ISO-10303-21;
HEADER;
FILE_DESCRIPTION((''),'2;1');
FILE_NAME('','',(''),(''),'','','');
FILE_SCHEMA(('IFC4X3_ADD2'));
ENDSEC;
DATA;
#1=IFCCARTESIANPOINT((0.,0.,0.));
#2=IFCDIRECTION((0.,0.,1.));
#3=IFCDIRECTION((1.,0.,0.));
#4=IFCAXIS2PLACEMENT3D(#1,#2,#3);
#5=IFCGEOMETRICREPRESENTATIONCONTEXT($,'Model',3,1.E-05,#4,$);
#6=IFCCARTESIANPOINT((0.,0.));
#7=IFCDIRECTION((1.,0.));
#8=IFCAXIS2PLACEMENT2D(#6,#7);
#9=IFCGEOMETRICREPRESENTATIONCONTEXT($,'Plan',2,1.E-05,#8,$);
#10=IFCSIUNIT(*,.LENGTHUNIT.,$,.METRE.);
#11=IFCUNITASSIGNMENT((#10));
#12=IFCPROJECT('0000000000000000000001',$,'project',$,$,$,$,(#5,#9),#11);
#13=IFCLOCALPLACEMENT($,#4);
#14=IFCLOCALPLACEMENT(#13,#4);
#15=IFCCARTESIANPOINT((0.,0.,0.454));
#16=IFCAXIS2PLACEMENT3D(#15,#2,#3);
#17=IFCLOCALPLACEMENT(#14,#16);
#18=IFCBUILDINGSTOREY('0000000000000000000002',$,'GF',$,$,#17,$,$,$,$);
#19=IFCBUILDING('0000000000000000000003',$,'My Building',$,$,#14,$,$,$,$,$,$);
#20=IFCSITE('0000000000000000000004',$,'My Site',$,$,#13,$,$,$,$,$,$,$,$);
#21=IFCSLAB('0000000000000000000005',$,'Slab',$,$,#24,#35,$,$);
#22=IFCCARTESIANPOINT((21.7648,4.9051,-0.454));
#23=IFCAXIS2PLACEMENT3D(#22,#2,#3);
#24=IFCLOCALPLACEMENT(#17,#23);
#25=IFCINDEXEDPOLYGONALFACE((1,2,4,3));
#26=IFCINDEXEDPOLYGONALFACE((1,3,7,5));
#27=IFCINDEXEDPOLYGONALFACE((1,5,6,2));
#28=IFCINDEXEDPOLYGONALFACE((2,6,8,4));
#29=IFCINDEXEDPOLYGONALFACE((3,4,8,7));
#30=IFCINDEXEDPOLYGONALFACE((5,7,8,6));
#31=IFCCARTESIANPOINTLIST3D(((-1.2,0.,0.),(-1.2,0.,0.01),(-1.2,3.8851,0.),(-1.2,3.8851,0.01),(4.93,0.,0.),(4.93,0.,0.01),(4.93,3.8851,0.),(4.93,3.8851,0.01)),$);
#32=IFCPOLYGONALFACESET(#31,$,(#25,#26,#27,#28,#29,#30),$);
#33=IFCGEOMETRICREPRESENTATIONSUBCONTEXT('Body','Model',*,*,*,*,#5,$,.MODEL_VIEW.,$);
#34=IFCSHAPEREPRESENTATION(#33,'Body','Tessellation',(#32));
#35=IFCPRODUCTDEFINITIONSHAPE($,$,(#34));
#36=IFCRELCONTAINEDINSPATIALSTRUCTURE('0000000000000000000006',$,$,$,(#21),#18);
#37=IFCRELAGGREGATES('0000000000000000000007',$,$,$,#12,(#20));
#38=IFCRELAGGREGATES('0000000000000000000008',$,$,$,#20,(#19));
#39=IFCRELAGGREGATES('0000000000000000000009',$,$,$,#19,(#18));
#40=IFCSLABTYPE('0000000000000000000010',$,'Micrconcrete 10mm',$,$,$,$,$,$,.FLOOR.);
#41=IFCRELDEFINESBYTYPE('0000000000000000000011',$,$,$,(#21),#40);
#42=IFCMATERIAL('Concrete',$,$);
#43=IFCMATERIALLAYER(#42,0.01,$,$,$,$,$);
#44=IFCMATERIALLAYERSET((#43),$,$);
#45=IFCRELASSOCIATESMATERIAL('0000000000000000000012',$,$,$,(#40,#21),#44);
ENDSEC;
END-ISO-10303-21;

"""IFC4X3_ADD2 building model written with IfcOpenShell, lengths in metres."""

from ifc_helpers import new_model, si_unit, frame, origin_with_axes, origin_2d_with_axis, place, context, subcontext, project, spatial, line, indexed_curve, outline, extrude, material, layer, layer_set, layer_usage, type_object, element, save


model = new_model("IFC4X3_ADD2")

# Units and contexts
model_context = context("Model", 3, precision=1e-05, world=origin_with_axes())
plan_context = context("Plan", 2, precision=1e-05, world=origin_2d_with_axis())
body_context = subcontext(model_context, "Body", "Model", "MODEL_VIEW")
ifc_project = project(units=[si_unit("LENGTHUNIT", "METRE")], contexts=[model_context, plan_context])

# Site, building, storey
site_placement = place(None, origin_with_axes())
site = spatial("IfcSite", under=ifc_project, at=site_placement, Name="My Site")
building_placement = place(site_placement, origin_with_axes())
building = spatial("IfcBuilding", under=site, at=building_placement, Name="My Building")
storey_placement = place(building_placement, frame((0.0, 0.0, 0.454), z_axis=(0.0, 0.0, 1.0), x_axis=(1.0, 0.0, 0.0)))
storey = spatial("IfcBuildingStorey", under=building, at=storey_placement, Name="GF")

# Shared definitions
ifc_material_1 = material(Name="Concrete")

# Slab
ifc_layer_1 = layer(ifc_material_1, 0.01)
ifc_layer_set_1 = layer_set([ifc_layer_1])
ifc_layer_usage_1 = layer_usage(ifc_layer_set_1, "AXIS3", "POSITIVE", 0.0)
slab_type = type_object("IfcSlabType", Name="Micrconcrete 10mm", PredefinedType="FLOOR", material=ifc_layer_set_1)
slab_placement = place(storey_placement, frame((21.7648, 4.9051, -0.454), z_axis=(0.0, 0.0, 1.0), x_axis=(1.0, 0.0, 0.0)))
element("IfcSlab", 1, at=slab_placement, inside=storey, type_object=slab_type, material=ifc_layer_usage_1, Name="Slab", context=body_context, shape_type="SweptSolid", body=[
    extrude(outline(indexed_curve([(-1.2, 3.8851), (4.93, 3.8851), (4.93, 0.0), (-1.2, 0.0)], segments=[line(4, 1), line(1, 2), line(2, 3), line(3, 4)], self_intersect=False)), None, (0.0, 0.0, 1.0), 0.01),
])

save(model, "model.ifc")
